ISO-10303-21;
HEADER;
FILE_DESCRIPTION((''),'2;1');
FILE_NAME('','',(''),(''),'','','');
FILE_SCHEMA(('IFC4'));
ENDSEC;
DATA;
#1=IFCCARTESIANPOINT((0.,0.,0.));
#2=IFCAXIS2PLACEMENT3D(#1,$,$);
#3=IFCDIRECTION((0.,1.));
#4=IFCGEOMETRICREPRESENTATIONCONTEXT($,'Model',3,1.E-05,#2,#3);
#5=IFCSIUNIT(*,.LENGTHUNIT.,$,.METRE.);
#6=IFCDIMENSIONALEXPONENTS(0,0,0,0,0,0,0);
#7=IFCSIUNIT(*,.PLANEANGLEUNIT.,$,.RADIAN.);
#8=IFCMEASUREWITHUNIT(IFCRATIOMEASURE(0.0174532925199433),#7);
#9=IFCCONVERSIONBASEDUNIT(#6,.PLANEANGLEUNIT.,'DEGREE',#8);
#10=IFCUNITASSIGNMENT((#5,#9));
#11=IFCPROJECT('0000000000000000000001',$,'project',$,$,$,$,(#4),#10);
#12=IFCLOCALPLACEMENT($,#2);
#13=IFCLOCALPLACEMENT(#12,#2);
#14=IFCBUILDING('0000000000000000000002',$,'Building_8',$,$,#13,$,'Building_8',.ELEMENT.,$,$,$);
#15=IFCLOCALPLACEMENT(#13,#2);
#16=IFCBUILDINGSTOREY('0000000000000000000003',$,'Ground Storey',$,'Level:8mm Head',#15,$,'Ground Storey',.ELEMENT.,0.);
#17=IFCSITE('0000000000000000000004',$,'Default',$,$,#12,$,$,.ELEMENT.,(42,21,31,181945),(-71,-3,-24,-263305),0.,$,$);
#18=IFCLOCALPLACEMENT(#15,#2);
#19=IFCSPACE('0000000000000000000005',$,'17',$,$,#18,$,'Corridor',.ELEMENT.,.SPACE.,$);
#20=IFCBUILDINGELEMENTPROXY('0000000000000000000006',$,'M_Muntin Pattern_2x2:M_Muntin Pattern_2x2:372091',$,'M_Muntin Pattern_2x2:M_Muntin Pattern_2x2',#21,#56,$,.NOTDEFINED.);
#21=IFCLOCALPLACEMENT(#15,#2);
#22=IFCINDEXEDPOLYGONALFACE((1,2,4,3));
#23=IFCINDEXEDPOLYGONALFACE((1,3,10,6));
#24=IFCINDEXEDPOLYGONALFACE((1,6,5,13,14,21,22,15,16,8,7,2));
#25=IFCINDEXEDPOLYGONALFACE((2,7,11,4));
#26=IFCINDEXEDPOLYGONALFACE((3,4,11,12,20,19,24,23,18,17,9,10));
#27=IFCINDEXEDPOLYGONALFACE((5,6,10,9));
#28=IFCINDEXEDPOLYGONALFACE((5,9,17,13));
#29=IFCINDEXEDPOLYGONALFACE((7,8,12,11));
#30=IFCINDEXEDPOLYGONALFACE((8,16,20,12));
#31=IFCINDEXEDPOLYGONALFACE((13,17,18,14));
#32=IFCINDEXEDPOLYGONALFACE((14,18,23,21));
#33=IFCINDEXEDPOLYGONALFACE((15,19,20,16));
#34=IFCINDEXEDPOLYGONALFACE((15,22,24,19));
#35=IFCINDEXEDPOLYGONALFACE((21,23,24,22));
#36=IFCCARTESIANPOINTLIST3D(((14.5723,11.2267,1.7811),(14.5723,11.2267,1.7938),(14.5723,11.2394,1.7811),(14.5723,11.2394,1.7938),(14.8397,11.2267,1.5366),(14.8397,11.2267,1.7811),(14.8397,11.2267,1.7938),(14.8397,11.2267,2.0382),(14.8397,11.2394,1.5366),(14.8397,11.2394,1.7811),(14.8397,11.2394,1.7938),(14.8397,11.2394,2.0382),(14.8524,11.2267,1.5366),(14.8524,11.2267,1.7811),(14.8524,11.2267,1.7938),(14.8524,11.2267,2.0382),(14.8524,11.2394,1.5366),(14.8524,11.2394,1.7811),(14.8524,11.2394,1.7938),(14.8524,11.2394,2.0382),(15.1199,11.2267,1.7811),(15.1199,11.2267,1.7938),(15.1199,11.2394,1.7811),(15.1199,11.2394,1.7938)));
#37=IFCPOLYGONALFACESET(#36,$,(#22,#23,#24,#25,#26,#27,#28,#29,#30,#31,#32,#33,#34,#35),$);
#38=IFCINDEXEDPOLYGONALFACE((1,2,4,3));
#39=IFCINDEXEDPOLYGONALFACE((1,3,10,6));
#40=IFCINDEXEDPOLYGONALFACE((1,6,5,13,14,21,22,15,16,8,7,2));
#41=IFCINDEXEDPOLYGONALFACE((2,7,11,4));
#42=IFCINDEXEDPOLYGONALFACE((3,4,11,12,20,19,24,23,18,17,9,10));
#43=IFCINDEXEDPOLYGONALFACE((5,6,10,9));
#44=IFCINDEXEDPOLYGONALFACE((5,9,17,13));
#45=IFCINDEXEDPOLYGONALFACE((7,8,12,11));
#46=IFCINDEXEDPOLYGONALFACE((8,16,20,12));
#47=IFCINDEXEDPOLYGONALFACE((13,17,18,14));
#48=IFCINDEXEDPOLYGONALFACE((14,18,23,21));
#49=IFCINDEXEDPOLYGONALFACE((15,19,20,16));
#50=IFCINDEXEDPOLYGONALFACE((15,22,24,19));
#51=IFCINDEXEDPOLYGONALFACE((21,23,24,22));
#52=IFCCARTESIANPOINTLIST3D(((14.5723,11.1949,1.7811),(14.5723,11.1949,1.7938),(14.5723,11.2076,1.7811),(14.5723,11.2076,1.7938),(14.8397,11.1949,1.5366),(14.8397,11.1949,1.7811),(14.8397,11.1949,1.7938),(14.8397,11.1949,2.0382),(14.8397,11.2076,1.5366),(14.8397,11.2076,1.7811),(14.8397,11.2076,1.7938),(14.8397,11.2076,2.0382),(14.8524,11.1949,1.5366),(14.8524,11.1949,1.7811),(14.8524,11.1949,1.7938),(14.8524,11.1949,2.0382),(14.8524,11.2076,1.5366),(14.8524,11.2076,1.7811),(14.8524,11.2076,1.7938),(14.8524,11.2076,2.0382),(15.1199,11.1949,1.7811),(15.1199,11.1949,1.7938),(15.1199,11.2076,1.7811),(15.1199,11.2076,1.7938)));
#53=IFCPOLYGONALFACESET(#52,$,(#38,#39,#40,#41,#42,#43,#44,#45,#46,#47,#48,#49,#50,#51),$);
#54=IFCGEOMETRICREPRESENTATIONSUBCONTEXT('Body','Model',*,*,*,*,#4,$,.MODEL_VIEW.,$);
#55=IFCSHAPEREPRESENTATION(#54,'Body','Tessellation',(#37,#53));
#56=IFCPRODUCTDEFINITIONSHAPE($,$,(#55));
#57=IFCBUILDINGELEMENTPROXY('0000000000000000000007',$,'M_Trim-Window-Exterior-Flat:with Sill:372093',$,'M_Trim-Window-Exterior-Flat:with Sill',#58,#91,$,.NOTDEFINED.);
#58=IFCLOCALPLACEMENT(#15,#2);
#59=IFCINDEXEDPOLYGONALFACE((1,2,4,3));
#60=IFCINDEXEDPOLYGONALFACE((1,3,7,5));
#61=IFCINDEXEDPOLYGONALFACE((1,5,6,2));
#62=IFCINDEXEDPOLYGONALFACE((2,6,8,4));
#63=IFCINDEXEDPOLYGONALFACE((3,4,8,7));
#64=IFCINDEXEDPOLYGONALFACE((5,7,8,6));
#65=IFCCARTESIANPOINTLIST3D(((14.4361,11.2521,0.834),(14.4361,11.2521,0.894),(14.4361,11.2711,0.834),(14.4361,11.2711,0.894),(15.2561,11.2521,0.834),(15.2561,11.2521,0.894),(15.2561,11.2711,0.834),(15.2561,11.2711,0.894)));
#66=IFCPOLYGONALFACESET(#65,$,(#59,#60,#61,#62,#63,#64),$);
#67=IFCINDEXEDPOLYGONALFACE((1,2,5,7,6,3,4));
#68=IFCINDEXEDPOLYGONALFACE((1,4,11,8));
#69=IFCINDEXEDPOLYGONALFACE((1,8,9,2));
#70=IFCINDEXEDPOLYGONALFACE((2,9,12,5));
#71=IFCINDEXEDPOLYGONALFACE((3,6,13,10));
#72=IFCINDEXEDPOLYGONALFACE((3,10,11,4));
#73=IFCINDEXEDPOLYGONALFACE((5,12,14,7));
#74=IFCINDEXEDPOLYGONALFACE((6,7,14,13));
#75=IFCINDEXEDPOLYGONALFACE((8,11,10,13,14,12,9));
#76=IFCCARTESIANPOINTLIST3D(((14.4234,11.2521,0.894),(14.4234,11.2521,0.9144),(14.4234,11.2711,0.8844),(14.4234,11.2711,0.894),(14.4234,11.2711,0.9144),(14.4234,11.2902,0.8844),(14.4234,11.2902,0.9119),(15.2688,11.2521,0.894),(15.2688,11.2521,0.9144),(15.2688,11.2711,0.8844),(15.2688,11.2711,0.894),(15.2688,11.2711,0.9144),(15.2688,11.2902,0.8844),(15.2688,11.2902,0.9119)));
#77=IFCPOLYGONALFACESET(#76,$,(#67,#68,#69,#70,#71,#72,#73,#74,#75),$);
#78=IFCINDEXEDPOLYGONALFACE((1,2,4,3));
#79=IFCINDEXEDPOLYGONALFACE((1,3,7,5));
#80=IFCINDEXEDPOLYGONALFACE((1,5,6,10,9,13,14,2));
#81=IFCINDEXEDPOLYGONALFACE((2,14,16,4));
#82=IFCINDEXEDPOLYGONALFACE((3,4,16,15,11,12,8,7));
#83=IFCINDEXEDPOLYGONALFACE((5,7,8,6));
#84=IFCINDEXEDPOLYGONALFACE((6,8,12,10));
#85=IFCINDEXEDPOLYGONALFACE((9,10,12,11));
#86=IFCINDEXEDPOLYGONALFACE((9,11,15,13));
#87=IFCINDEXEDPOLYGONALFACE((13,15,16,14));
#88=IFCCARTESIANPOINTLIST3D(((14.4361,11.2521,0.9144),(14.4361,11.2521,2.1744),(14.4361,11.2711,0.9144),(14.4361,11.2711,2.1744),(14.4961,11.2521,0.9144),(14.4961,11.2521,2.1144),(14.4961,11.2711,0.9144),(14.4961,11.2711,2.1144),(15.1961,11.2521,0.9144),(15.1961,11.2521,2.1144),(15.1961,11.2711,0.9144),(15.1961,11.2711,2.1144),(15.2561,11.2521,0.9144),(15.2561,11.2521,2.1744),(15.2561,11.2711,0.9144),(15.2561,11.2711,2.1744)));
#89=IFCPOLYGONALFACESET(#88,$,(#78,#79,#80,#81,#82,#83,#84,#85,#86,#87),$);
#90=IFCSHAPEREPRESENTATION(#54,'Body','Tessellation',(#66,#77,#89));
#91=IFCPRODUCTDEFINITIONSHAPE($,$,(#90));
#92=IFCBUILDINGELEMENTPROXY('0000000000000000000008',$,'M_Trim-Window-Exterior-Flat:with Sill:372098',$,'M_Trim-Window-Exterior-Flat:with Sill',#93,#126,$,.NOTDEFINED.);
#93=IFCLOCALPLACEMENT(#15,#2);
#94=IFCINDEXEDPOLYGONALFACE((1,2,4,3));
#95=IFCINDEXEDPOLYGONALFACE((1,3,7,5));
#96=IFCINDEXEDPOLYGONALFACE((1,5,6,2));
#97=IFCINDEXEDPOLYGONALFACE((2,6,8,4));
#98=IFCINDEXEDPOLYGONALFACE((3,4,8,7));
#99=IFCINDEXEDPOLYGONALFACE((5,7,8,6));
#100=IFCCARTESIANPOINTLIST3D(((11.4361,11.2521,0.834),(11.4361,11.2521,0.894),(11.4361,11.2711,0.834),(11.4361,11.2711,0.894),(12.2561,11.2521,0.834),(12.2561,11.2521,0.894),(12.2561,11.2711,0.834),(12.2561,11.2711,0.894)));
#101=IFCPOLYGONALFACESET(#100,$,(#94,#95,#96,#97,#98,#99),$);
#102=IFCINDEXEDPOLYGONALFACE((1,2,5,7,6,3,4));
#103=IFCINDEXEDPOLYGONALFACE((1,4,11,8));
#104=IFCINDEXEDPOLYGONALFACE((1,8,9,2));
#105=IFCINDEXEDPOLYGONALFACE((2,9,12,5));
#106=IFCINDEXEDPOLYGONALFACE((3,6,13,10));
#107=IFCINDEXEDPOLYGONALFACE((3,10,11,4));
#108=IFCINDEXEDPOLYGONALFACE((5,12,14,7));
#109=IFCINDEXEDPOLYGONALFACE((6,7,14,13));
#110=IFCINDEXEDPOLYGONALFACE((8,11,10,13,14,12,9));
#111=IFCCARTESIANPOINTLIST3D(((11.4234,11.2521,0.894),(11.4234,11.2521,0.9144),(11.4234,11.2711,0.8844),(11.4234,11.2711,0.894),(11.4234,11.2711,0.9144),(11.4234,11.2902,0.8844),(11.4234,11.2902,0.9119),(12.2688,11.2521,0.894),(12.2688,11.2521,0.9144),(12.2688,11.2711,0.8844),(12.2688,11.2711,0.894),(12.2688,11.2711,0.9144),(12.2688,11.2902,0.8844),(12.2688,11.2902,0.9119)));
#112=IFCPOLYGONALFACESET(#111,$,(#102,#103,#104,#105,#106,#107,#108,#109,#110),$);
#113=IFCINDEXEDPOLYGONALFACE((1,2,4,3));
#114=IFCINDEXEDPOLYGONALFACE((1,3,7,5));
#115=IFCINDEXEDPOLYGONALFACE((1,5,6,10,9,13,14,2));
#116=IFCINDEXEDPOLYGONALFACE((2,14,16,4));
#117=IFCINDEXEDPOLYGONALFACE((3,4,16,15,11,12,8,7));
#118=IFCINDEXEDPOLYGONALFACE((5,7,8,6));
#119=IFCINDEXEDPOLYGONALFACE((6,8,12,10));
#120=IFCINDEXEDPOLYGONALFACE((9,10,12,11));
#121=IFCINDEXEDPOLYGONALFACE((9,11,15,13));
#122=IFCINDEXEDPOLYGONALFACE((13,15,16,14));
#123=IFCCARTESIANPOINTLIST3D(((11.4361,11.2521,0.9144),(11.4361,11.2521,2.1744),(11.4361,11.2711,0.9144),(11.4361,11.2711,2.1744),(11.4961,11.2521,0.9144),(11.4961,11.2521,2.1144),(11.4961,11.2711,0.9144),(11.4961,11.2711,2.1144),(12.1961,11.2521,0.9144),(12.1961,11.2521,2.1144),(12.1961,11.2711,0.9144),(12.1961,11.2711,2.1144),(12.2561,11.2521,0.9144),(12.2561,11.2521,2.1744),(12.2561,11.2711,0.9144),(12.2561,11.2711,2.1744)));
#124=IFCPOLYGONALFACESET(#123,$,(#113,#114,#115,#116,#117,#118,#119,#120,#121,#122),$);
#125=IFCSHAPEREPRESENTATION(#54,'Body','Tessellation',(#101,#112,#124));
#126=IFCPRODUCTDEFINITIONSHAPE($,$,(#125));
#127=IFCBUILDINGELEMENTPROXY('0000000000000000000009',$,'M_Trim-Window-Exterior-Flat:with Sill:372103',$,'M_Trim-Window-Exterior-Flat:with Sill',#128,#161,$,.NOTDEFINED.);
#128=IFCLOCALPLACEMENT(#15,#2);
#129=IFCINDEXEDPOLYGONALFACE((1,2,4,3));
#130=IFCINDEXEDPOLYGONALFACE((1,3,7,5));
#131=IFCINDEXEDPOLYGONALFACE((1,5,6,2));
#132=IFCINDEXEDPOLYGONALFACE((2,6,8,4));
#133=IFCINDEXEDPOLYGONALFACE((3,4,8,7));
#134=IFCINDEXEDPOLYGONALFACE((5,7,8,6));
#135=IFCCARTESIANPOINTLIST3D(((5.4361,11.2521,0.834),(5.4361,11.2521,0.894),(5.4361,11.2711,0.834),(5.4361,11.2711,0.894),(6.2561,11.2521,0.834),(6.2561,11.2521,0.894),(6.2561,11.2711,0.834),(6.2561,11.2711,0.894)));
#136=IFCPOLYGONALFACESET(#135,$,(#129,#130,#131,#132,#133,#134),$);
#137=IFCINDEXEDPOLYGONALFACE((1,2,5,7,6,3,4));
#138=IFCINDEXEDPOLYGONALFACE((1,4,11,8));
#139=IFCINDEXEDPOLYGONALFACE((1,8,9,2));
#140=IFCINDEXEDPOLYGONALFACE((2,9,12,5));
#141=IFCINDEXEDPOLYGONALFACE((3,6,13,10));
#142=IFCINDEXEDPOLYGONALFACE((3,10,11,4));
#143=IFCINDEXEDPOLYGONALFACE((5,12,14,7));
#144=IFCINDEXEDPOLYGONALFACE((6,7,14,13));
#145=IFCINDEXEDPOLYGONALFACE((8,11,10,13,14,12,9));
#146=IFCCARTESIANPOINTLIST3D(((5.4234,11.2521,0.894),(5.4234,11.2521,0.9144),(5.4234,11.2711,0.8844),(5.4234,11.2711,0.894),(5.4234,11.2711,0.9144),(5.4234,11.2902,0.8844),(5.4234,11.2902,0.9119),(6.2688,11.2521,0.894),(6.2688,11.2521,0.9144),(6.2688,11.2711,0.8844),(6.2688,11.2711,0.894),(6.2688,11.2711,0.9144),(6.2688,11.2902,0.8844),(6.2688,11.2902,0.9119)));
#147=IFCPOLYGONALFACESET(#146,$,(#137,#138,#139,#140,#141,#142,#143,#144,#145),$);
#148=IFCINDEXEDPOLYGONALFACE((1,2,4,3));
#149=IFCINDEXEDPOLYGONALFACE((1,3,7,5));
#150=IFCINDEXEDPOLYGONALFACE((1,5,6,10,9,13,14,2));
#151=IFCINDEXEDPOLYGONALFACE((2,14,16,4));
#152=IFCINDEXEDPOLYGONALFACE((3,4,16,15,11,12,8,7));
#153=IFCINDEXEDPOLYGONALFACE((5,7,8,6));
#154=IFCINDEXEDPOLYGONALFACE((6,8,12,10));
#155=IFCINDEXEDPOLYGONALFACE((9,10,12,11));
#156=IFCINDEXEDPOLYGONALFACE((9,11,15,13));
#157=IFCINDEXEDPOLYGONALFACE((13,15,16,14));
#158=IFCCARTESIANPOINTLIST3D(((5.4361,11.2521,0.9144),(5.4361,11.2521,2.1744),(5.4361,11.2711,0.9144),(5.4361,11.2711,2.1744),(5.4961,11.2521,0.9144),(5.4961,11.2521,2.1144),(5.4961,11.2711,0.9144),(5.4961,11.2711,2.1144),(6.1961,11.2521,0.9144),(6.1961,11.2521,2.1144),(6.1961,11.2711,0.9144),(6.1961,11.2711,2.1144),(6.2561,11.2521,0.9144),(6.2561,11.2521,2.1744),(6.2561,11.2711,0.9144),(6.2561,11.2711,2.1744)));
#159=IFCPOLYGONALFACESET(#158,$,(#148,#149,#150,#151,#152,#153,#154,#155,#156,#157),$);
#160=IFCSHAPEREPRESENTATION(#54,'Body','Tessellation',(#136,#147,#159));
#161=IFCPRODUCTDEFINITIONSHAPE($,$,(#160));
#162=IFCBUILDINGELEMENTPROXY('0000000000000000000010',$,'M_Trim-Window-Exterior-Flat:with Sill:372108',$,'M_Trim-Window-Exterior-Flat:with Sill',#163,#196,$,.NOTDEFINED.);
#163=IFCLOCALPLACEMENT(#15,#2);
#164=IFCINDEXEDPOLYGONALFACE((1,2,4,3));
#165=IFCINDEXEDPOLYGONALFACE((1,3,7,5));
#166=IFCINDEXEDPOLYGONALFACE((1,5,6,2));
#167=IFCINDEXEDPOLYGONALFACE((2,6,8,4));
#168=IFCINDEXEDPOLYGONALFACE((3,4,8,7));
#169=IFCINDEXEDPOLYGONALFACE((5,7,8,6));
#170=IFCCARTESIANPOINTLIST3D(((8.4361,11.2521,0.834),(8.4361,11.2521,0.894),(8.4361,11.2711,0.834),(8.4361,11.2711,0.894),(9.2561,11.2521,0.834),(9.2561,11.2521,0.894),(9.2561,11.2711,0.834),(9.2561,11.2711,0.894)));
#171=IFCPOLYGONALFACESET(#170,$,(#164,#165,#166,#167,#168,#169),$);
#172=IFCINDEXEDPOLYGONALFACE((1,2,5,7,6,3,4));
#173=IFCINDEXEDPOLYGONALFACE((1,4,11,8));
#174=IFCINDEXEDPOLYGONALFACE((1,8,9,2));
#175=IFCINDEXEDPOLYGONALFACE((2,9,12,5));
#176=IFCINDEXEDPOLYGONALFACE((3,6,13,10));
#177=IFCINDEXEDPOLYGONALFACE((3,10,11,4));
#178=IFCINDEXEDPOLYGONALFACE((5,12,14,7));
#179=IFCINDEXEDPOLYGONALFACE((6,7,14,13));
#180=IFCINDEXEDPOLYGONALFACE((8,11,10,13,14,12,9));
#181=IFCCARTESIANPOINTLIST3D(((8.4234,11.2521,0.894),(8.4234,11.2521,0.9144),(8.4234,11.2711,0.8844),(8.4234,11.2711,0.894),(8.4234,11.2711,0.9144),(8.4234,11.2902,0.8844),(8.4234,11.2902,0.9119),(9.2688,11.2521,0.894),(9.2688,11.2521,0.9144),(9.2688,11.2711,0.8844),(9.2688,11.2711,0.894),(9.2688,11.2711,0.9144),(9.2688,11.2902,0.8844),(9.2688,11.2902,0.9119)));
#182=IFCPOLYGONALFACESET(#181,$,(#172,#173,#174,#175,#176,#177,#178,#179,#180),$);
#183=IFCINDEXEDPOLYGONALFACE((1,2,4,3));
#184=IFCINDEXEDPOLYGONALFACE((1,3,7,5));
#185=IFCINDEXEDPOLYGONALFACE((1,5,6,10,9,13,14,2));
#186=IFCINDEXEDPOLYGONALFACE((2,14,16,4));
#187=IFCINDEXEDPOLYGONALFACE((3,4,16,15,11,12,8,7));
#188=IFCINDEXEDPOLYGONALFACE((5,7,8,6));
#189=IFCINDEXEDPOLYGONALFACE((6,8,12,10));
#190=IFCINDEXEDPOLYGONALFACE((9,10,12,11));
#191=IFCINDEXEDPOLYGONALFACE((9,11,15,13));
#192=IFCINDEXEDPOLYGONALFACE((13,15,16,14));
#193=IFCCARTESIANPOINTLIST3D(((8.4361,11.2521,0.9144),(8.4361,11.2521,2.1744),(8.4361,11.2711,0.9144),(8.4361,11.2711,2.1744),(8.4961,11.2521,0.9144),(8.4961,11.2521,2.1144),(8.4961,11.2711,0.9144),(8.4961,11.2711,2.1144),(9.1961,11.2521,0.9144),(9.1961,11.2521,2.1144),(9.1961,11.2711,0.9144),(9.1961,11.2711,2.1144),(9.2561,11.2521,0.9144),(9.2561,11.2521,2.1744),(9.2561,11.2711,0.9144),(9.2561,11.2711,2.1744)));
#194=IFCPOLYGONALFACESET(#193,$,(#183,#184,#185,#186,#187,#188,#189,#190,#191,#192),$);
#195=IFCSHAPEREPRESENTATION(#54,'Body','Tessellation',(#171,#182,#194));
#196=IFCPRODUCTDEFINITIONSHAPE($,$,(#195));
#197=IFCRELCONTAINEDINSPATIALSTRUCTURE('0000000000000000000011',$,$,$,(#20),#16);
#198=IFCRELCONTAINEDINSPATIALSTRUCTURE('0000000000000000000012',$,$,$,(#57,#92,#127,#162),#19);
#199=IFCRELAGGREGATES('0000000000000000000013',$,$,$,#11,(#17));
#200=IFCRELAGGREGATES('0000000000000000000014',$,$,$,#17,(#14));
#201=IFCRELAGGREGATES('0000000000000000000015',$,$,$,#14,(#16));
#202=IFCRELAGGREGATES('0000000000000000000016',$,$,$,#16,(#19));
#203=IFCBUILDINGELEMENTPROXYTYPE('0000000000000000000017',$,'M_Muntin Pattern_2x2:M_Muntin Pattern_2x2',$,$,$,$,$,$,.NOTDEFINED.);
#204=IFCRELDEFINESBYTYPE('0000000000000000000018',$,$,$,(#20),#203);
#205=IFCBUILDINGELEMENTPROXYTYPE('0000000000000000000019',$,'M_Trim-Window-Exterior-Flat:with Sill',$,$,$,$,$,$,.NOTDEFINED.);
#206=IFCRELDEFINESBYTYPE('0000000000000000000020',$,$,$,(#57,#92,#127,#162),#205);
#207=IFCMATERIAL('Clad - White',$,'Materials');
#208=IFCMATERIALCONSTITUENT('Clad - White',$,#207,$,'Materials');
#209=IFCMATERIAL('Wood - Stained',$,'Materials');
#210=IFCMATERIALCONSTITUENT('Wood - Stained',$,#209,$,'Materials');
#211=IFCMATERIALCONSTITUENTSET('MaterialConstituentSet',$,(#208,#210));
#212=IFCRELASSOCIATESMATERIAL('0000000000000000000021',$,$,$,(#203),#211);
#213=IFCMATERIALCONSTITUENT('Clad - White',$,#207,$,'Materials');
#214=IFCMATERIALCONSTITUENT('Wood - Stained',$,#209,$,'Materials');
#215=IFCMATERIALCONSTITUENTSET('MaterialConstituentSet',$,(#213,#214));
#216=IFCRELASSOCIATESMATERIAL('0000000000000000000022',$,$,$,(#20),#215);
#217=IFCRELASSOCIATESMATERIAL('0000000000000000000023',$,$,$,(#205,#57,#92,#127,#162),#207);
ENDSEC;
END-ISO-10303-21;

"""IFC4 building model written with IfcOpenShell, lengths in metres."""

from ifc_helpers import new_model, entity, si_unit, converted_unit, direction, frame, origin, place, context, subcontext, project, spatial, indexed_curve, outline, extrude, source, transform, mapped, material, constituent, constituent_set, type_object, type_shapes, element, save


model = new_model("IFC4")

# Units and contexts
model_context = context("Model", 3, precision=1e-05, world=origin(), true_north=direction((0.0, 1.0)))
body_context = subcontext(model_context, "Body", "Model", "MODEL_VIEW")
ifc_project = project(units=[si_unit("LENGTHUNIT", "METRE"), converted_unit("PLANEANGLEUNIT", "DEGREE", entity("IfcRatioMeasure", 0.0174532925199433), si_unit("PLANEANGLEUNIT", "RADIAN"), dimensions=[0, 0, 0, 0, 0, 0, 0])], contexts=[model_context])

# Site, building, storey
site_placement = place(None, origin())
site = spatial("IfcSite", under=ifc_project, at=site_placement, Name="Default", CompositionType="ELEMENT", RefLatitude=(42, 21, 31, 181945), RefLongitude=(-71, -3, -24, -263305), RefElevation=0.0)
building_placement = place(site_placement, origin())
building = spatial("IfcBuilding", under=site, at=building_placement, Name="Building_8", LongName="Building_8", CompositionType="ELEMENT")
storey_placement = place(building_placement, origin())
storey = spatial("IfcBuildingStorey", under=building, at=storey_placement, Name="Ground Storey", ObjectType="Level:8mm Head", LongName="Ground Storey", CompositionType="ELEMENT", Elevation=0.0)

# Shared definitions
ifc_material_1 = material(Name="Clad - White", Category="Materials")
ifc_material_2 = material(Name="Wood - Stained", Category="Materials")

# Shared definitions
space_1_placement = place(storey_placement, origin())
space_1 = spatial("IfcSpace", under=storey, at=space_1_placement, Name="17", LongName="Corridor", CompositionType="ELEMENT", PredefinedType="SPACE")

# Building element proxies
ifc_constituent_1 = constituent(ifc_material_1, Name="Clad - White", Category="Materials")
ifc_constituent_2 = constituent(ifc_material_2, Name="Wood - Stained", Category="Materials")
ifc_constituent_set_1 = constituent_set(constituents=[ifc_constituent_1, ifc_constituent_2], Name="MaterialConstituentSet")
ifc_constituent_3 = constituent(ifc_material_1, Name="Clad - White", Category="Materials")
ifc_constituent_4 = constituent(ifc_material_2, Name="Wood - Stained", Category="Materials")
ifc_constituent_set_2 = constituent_set(constituents=[ifc_constituent_3, ifc_constituent_4], Name="MaterialConstituentSet")
building_element_proxy_type_1 = type_object("IfcBuildingElementProxyType", Name="M_Muntin Pattern_2x2:M_Muntin Pattern_2x2", PredefinedType="NOTDEFINED", material=ifc_constituent_set_2)
shared_shape_1 = source(origin(), body_context, "Body", "SweptSolid", [
    extrude(outline(indexed_curve([(0.0064, -0.0064), (0.2508, -0.0064), (0.2508, 0.0063), (0.0064, 0.0063), (0.0064, 0.2738), (-0.0063, 0.2738), (-0.0063, 0.0063), (-0.2508, 0.0063), (-0.2508, -0.0064), (-0.0063, -0.0064), (-0.0063, -0.2738), (0.0064, -0.2738), (0.0064, -0.0064)], self_intersect=False)), frame((0.0, 0.0095, 0.2508), z_axis=(0.0, 1.0, 0.0), x_axis=(0.0, 0.0, 1.0)), (0.0, 0.0, 1.0), 0.0127),
    extrude(outline(indexed_curve([(0.0064, -0.0064), (0.2508, -0.0064), (0.2508, 0.0063), (0.0064, 0.0063), (0.0064, 0.2738), (-0.0063, 0.2738), (-0.0063, 0.0063), (-0.2508, 0.0063), (-0.2508, -0.0064), (-0.0063, -0.0064), (-0.0063, -0.2738), (0.0064, -0.2738), (0.0064, -0.0064)], self_intersect=False)), frame((0.0, -0.0222, 0.2508), z_axis=(0.0, 1.0, 0.0), x_axis=(0.0, 0.0, 1.0)), (0.0, 0.0, 1.0), 0.0127),
])
type_shapes(building_element_proxy_type_1, [shared_shape_1])
proxy_1_placement = place(storey_placement, frame((14.8461, 11.2171, 1.5366)))
element("IfcBuildingElementProxy", 1, at=proxy_1_placement, inside=storey, type_object=building_element_proxy_type_1, material=ifc_constituent_set_1, Name="M_Muntin Pattern_2x2:M_Muntin Pattern_2x2:372091", ObjectType="M_Muntin Pattern_2x2:M_Muntin Pattern_2x2", PredefinedType="NOTDEFINED", context=body_context, shape_type="MappedRepresentation", body=[
    mapped(shared_shape_1, transform((0.0, 0.0, 0.0), scale=1.0)),
])
building_element_proxy_type_2 = type_object("IfcBuildingElementProxyType", Name="M_Trim-Window-Exterior-Flat:with Sill", PredefinedType="NOTDEFINED", material=ifc_material_1)
shared_shape_2 = source(origin(), body_context, "Body", "SweptSolid", [
    extrude(outline(indexed_curve([(-0.41, -0.03), (0.41, -0.03), (0.41, 0.03), (-0.41, 0.03), (-0.41, -0.03)], self_intersect=False)), frame((0.0, -1.2504, 0.0), z_axis=(0.0, 0.0, 1.0), x_axis=(-1.0, 0.0, 0.0)), (0.0, 0.0, 1.0), 0.0191),
    extrude(outline(indexed_curve([(-0.019, -0.0152), (0.0, -0.0152), (0.0, -0.0057), (0.019, -0.0057), (0.019, 0.0148), (0.0, 0.0148), (-0.019, 0.0123), (-0.019, -0.0152)], self_intersect=False)), frame((-0.4227, -1.2148, 0.019), z_axis=(1.0, 0.0, 0.0), x_axis=(0.0, 0.0, -1.0)), (0.0, 0.0, 1.0), 0.8454),
    extrude(outline(indexed_curve([(-0.645, -0.41), (0.615, -0.41), (0.615, -0.35), (-0.585, -0.35), (-0.585, 0.35), (0.615, 0.35), (0.615, 0.41), (-0.645, 0.41), (-0.645, -0.41)], self_intersect=False)), frame((0.0, -0.585, 0.0), z_axis=(0.0, 0.0, 1.0), x_axis=(0.0, -1.0, 0.0)), (0.0, 0.0, 1.0), 0.0191),
])
type_shapes(building_element_proxy_type_2, [shared_shape_2])
for number, where, z_axis, x_axis, name in (
    (2, (14.8461, 11.2521, 2.1144), (0.0, 1.0, 0.0), (-1.0, 0.0, 0.0), "M_Trim-Window-Exterior-Flat:with Sill:372093"),
    (3, (11.8461, 11.2521, 2.1144), (0.0, 1.0, 0.0), (-1.0, 0.0, 0.0), "M_Trim-Window-Exterior-Flat:with Sill:372098"),
    (4, (5.8461, 11.2521, 2.1144), (0.0, 1.0, 0.0), (-1.0, 0.0, 0.0), "M_Trim-Window-Exterior-Flat:with Sill:372103"),
    (5, (8.8461, 11.2521, 2.1144), (0.0, 1.0, 0.0), (-1.0, 0.0, 0.0), "M_Trim-Window-Exterior-Flat:with Sill:372108"),
):
    element("IfcBuildingElementProxy", number, at=place(space_1_placement, frame(where, z_axis=z_axis, x_axis=x_axis)), inside=space_1, type_object=building_element_proxy_type_2, material=ifc_material_1, Name=name, ObjectType="M_Trim-Window-Exterior-Flat:with Sill", PredefinedType="NOTDEFINED", context=body_context, shape_type="MappedRepresentation", body=[
        mapped(shared_shape_2, transform((0.0, 0.0, 0.0), scale=1.0)),
    ])

save(model, "model.ifc")
